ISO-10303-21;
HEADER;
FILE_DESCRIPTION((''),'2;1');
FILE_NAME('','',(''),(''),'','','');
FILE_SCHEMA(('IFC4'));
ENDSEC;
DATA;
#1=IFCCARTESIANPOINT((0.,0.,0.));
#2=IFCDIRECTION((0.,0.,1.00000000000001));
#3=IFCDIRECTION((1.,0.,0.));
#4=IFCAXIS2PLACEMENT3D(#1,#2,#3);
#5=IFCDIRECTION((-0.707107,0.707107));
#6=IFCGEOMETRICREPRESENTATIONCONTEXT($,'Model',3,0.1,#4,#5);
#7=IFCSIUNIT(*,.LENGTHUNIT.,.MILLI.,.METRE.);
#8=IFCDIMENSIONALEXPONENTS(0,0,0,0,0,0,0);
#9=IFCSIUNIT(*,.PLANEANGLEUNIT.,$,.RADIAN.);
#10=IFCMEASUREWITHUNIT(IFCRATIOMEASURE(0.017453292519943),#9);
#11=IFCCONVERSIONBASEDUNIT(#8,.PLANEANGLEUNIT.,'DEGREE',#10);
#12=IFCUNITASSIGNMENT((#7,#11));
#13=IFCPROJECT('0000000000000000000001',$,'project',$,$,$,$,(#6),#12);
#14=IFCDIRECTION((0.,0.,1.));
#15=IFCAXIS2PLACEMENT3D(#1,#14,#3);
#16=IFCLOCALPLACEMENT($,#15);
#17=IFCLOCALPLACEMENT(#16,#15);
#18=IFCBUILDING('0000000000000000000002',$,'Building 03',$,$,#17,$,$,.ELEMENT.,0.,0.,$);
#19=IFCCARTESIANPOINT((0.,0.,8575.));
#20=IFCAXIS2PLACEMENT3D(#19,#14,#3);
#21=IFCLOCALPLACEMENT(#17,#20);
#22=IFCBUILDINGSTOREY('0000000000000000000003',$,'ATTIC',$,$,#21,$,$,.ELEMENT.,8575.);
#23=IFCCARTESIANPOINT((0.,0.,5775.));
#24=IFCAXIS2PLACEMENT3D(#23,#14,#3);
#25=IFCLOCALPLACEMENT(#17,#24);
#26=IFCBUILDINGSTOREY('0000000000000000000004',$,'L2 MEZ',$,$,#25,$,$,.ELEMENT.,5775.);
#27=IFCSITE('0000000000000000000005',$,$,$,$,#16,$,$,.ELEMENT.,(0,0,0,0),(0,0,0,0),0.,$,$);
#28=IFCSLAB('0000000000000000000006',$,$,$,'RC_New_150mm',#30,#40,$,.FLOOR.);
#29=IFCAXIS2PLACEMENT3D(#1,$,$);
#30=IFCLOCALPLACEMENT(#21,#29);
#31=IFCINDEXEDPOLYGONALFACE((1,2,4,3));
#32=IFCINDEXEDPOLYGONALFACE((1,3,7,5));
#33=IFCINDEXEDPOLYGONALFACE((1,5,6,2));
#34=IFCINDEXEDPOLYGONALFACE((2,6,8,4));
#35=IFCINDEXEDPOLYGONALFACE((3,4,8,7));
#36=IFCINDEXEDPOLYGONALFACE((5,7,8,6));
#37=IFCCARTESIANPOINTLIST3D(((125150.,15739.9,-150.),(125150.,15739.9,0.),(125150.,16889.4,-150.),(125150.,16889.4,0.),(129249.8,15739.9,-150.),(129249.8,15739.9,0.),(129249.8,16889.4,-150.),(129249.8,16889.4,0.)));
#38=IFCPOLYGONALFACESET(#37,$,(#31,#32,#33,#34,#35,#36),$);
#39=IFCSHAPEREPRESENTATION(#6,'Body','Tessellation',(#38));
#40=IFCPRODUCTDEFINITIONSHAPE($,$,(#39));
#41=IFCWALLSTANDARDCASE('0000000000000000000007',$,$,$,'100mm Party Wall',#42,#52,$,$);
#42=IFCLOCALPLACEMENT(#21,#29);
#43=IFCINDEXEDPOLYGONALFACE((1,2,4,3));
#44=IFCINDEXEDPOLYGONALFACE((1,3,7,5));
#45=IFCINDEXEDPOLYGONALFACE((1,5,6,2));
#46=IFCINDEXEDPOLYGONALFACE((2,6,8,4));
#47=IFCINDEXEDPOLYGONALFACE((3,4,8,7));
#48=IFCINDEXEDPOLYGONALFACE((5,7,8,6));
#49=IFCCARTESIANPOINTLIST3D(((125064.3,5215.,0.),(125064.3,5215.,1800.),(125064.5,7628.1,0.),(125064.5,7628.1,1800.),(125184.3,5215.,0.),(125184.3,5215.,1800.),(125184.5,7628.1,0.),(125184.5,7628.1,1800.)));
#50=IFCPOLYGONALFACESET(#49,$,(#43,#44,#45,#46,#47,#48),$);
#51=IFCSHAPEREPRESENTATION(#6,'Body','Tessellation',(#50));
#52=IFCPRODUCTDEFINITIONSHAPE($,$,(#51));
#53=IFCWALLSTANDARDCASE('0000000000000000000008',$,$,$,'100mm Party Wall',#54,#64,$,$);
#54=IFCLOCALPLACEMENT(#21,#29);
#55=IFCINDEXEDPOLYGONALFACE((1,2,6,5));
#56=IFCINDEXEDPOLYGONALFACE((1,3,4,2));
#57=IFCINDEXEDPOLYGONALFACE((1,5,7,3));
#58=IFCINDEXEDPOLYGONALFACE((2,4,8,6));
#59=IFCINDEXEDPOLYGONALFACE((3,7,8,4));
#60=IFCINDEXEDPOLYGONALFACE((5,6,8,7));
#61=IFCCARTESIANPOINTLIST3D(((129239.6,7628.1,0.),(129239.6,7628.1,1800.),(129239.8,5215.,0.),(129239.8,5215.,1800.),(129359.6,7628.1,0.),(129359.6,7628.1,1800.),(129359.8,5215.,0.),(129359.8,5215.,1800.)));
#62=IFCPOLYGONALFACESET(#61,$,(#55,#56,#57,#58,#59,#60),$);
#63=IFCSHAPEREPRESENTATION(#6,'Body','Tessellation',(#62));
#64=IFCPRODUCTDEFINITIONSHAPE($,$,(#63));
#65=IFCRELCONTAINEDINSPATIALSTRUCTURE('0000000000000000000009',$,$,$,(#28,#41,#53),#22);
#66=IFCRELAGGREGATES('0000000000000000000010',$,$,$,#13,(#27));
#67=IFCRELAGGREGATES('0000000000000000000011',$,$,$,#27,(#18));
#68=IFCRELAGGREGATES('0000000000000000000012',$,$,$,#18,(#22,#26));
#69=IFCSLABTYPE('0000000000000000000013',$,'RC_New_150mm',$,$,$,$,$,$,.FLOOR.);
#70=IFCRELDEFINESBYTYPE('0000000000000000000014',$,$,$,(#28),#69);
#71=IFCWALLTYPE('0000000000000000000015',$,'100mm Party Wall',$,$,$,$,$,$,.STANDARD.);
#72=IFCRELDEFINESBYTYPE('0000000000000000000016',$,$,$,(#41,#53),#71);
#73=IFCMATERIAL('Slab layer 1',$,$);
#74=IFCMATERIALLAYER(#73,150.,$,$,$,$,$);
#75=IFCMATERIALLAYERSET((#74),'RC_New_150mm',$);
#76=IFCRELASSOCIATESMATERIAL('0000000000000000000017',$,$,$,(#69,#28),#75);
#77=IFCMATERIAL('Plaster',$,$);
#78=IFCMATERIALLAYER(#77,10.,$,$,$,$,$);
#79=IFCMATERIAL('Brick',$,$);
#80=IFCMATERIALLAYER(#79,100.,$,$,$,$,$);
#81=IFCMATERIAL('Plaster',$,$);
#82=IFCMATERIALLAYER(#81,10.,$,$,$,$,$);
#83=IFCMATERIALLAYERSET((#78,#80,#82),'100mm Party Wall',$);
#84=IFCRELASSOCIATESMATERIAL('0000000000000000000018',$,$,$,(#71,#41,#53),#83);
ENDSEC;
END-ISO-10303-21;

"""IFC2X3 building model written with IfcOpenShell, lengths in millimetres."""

from ifc_helpers import new_model, entity, si_unit, converted_unit, direction, frame, origin_with_axes, place, context, project, spatial, polyline, outline, extrude, material, layer, layer_set, layer_usage, type_object, element, save


model = new_model("IFC2X3")

# Units and contexts
model_context = context("Model", 3, precision=0.1, world=frame((0.0, 0.0, 0.0), z_axis=(0.0, 0.0, 1.00000000000001), x_axis=(1.0, 0.0, 0.0)), true_north=direction((-0.707107, 0.707107)))
ifc_project = project(units=[si_unit("LENGTHUNIT", "METRE", prefix="MILLI"), converted_unit("PLANEANGLEUNIT", "DEGREE", entity("IfcRatioMeasure", 0.017453292519943), si_unit("PLANEANGLEUNIT", "RADIAN"), dimensions=[0, 0, 0, 0, 0, 0, 0])], contexts=[model_context])

# Site, building, storey
site_placement = place(None, origin_with_axes())
site = spatial("IfcSite", under=ifc_project, at=site_placement, CompositionType="ELEMENT", RefLatitude=(0, 0, 0, 0), RefLongitude=(0, 0, 0, 0), RefElevation=0.0)
building_placement = place(site_placement, origin_with_axes())
building = spatial("IfcBuilding", under=site, at=building_placement, Name="Building 03", CompositionType="ELEMENT", ElevationOfRefHeight=0.0, ElevationOfTerrain=0.0)
storey_1_placement = place(building_placement, frame((0.0, 0.0, 8575.0), z_axis=(0.0, 0.0, 1.0), x_axis=(1.0, 0.0, 0.0)))
storey_1 = spatial("IfcBuildingStorey", under=building, at=storey_1_placement, Name="ATTIC", CompositionType="ELEMENT", Elevation=8575.0)

# Slab
ifc_material_1 = material(Name="Slab layer 1")
ifc_layer_1 = layer(ifc_material_1, 150.0)
ifc_layer_set_1 = layer_set([ifc_layer_1], Name="RC_New_150mm")
ifc_layer_usage_1 = layer_usage(ifc_layer_set_1, "AXIS3", "POSITIVE", 0.0)
slab_type_1 = type_object("IfcSlabType", Name="RC_New_150mm", PredefinedType="FLOOR", material=ifc_layer_set_1)
slab_1_placement = place(site_placement, frame((125150.0, 16889.4, 8575.0), z_axis=(0.0, 0.0, 1.0), x_axis=(-1.0, 0.0, 0.0)))
element("IfcSlab", 1, at=slab_1_placement, inside=storey_1, type_object=slab_type_1, material=ifc_layer_usage_1, ObjectType="RC_New_150mm", PredefinedType="FLOOR", context=model_context, shape_type="SweptSolid", body=[
    extrude(outline(polyline([(0.0, 0.0), (-4099.8, 0.0), (-4099.8, 1149.5), (0.0, 1149.5), (0.0, 0.0)])), frame((0.0, 0.0, -150.0), z_axis=(0.0, 0.0, 1.0), x_axis=(1.0, 0.0, 0.0)), (0.0, 0.0, 1.0), 150.0),
])

# Shared definitions
storey_2_placement = place(building_placement, frame((0.0, 0.0, 5775.0), z_axis=(0.0, 0.0, 1.0), x_axis=(1.0, 0.0, 0.0)))
storey_2 = spatial("IfcBuildingStorey", under=building, at=storey_2_placement, Name="L2 MEZ", CompositionType="ELEMENT", Elevation=5775.0)

# Walls
ifc_material_2 = material(Name="Plaster")
ifc_layer_2 = layer(ifc_material_2, 10.0)
ifc_material_3 = material(Name="Brick")
ifc_layer_3 = layer(ifc_material_3, 100.0)
ifc_material_4 = material(Name="Plaster")
ifc_layer_4 = layer(ifc_material_4, 10.0)
ifc_layer_set_2 = layer_set([ifc_layer_2, ifc_layer_3, ifc_layer_4], Name="100mm Party Wall")
ifc_layer_usage_2 = layer_usage(ifc_layer_set_2, "AXIS2", "POSITIVE", -60.0)
wall_type_1 = type_object("IfcWallType", Name="100mm Party Wall", PredefinedType="STANDARD", material=ifc_layer_set_2)
wall_1_placement = place(site_placement, frame((125064.5, 7628.1, 8575.0), z_axis=(0.0, 0.0, 1.0), x_axis=(-0.000084, -1.0, 0.0)))
element("IfcWallStandardCase", 2, at=wall_1_placement, inside=storey_1, type_object=wall_type_1, material=ifc_layer_usage_2, ObjectType="100mm Party Wall", context=model_context, shape_type="SweptSolid", body=[
    extrude(outline(polyline([(2413.1, 120.0), (0.0, 120.0), (0.0, 0.0), (2413.1, 0.0), (2413.1, 120.0)])), origin_with_axes(), (0.0, 0.0, 1.0), 1800.0),
])
wall_2_placement = place(site_placement, frame((129359.8, 5215.0, 8575.0), z_axis=(0.0, 0.0, 1.0), x_axis=(-0.000084, 1.0, 0.0)))
element("IfcWallStandardCase", 3, at=wall_2_placement, inside=storey_1, type_object=wall_type_1, material=ifc_layer_usage_2, ObjectType="100mm Party Wall", context=model_context, shape_type="SweptSolid", body=[
    extrude(outline(polyline([(2413.1, 120.0), (0.0, 120.0), (0.0, 0.0), (2413.1, 0.0), (2413.1, 120.0)])), origin_with_axes(), (0.0, 0.0, 1.0), 1800.0),
])

save(model, "model.ifc")
